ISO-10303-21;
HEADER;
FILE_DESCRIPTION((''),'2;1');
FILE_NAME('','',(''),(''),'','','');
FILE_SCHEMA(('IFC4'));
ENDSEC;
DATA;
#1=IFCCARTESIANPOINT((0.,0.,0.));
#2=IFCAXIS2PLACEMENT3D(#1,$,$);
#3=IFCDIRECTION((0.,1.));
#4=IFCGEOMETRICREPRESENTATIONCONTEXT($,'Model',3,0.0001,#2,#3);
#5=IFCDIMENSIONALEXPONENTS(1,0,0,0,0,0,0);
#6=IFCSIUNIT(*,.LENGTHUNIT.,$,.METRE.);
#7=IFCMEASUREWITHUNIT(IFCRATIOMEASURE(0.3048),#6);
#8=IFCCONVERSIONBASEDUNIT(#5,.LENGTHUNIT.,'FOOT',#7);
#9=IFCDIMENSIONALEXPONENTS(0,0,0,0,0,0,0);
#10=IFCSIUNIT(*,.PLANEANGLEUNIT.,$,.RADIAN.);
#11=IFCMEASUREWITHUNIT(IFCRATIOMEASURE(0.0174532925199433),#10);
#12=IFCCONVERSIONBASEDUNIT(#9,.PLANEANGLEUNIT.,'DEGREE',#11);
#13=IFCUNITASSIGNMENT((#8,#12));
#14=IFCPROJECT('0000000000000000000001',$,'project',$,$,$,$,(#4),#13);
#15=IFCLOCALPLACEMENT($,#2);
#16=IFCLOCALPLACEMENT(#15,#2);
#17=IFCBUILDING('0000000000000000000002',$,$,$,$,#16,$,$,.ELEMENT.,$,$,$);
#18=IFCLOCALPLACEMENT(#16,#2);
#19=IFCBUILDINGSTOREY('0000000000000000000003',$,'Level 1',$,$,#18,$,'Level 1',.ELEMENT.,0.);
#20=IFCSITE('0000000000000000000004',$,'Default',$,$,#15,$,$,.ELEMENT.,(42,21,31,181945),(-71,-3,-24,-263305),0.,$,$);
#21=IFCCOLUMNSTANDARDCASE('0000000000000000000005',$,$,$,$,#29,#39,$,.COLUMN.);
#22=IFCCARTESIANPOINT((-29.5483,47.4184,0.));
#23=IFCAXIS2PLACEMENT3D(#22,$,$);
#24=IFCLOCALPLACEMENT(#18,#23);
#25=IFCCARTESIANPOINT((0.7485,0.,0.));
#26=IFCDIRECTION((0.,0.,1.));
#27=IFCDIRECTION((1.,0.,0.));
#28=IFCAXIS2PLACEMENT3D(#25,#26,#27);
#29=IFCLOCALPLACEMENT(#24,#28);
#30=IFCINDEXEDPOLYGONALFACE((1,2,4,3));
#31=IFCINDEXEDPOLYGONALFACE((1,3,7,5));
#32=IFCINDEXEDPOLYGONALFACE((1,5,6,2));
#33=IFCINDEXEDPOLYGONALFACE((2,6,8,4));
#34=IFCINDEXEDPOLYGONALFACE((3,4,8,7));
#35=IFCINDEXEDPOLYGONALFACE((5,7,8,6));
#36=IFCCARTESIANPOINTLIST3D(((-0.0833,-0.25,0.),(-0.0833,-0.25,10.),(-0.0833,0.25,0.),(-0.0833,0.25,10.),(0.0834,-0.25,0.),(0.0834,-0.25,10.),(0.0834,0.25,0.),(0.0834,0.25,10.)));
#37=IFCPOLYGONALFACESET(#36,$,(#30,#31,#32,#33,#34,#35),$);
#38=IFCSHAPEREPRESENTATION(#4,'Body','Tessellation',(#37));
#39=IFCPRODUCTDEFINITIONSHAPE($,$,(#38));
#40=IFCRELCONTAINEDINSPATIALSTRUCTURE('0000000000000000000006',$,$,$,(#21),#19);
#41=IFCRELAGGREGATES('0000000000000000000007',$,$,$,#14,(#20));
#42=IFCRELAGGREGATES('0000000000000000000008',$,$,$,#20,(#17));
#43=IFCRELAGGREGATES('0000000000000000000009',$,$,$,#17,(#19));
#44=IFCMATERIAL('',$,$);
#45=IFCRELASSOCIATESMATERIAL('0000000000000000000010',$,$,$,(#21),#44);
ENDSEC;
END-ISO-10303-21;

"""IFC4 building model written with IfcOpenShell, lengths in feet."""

from ifc_helpers import new_model, entity, si_unit, converted_unit, direction, frame, origin, place, context, project, spatial, rectangle, extrude, material, element, save


model = new_model("IFC4")

# Units and contexts
model_context = context("Model", 3, precision=0.0001, world=origin(), true_north=direction((0.0, 1.0)))
ifc_project = project(units=[converted_unit("LENGTHUNIT", "FOOT", entity("IfcRatioMeasure", 0.3048), si_unit("LENGTHUNIT", "METRE"), dimensions=[1, 0, 0, 0, 0, 0, 0]), converted_unit("PLANEANGLEUNIT", "DEGREE", entity("IfcRatioMeasure", 0.0174532925199433), si_unit("PLANEANGLEUNIT", "RADIAN"), dimensions=[0, 0, 0, 0, 0, 0, 0])], contexts=[model_context])

# Site, building, storey
site_placement = place(None, origin())
site = spatial("IfcSite", under=ifc_project, at=site_placement, Name="Default", CompositionType="ELEMENT", RefLatitude=(42, 21, 31, 181945), RefLongitude=(-71, -3, -24, -263305), RefElevation=0.0)
building_placement = place(site_placement, origin())
building = spatial("IfcBuilding", under=site, at=building_placement, CompositionType="ELEMENT")
storey_placement = place(building_placement, origin())
storey = spatial("IfcBuildingStorey", under=building, at=storey_placement, Name="Level 1", LongName="Level 1", CompositionType="ELEMENT", Elevation=0.0)

# Column
ifc_material_1 = material(Name="")
wall_placement = place(storey_placement, frame((-29.5483, 47.4184, 0.0)))
for number, where, z_axis, x_axis in (
    (1, (0.7485, 0.0, 0.0), (0.0, 0.0, 1.0), (1.0, 0.0, 0.0)),
):
    element("IfcColumnStandardCase", number, at=place(wall_placement, frame(where, z_axis=z_axis, x_axis=x_axis)), inside=storey, material=ifc_material_1, PredefinedType="COLUMN", context=model_context, shape_type="SweptSolid", body=[
        extrude(rectangle(XDim=0.1667, YDim=0.5), origin(), (0.0, 0.0, 1.0), 10.0),
    ])

save(model, "model.ifc")
